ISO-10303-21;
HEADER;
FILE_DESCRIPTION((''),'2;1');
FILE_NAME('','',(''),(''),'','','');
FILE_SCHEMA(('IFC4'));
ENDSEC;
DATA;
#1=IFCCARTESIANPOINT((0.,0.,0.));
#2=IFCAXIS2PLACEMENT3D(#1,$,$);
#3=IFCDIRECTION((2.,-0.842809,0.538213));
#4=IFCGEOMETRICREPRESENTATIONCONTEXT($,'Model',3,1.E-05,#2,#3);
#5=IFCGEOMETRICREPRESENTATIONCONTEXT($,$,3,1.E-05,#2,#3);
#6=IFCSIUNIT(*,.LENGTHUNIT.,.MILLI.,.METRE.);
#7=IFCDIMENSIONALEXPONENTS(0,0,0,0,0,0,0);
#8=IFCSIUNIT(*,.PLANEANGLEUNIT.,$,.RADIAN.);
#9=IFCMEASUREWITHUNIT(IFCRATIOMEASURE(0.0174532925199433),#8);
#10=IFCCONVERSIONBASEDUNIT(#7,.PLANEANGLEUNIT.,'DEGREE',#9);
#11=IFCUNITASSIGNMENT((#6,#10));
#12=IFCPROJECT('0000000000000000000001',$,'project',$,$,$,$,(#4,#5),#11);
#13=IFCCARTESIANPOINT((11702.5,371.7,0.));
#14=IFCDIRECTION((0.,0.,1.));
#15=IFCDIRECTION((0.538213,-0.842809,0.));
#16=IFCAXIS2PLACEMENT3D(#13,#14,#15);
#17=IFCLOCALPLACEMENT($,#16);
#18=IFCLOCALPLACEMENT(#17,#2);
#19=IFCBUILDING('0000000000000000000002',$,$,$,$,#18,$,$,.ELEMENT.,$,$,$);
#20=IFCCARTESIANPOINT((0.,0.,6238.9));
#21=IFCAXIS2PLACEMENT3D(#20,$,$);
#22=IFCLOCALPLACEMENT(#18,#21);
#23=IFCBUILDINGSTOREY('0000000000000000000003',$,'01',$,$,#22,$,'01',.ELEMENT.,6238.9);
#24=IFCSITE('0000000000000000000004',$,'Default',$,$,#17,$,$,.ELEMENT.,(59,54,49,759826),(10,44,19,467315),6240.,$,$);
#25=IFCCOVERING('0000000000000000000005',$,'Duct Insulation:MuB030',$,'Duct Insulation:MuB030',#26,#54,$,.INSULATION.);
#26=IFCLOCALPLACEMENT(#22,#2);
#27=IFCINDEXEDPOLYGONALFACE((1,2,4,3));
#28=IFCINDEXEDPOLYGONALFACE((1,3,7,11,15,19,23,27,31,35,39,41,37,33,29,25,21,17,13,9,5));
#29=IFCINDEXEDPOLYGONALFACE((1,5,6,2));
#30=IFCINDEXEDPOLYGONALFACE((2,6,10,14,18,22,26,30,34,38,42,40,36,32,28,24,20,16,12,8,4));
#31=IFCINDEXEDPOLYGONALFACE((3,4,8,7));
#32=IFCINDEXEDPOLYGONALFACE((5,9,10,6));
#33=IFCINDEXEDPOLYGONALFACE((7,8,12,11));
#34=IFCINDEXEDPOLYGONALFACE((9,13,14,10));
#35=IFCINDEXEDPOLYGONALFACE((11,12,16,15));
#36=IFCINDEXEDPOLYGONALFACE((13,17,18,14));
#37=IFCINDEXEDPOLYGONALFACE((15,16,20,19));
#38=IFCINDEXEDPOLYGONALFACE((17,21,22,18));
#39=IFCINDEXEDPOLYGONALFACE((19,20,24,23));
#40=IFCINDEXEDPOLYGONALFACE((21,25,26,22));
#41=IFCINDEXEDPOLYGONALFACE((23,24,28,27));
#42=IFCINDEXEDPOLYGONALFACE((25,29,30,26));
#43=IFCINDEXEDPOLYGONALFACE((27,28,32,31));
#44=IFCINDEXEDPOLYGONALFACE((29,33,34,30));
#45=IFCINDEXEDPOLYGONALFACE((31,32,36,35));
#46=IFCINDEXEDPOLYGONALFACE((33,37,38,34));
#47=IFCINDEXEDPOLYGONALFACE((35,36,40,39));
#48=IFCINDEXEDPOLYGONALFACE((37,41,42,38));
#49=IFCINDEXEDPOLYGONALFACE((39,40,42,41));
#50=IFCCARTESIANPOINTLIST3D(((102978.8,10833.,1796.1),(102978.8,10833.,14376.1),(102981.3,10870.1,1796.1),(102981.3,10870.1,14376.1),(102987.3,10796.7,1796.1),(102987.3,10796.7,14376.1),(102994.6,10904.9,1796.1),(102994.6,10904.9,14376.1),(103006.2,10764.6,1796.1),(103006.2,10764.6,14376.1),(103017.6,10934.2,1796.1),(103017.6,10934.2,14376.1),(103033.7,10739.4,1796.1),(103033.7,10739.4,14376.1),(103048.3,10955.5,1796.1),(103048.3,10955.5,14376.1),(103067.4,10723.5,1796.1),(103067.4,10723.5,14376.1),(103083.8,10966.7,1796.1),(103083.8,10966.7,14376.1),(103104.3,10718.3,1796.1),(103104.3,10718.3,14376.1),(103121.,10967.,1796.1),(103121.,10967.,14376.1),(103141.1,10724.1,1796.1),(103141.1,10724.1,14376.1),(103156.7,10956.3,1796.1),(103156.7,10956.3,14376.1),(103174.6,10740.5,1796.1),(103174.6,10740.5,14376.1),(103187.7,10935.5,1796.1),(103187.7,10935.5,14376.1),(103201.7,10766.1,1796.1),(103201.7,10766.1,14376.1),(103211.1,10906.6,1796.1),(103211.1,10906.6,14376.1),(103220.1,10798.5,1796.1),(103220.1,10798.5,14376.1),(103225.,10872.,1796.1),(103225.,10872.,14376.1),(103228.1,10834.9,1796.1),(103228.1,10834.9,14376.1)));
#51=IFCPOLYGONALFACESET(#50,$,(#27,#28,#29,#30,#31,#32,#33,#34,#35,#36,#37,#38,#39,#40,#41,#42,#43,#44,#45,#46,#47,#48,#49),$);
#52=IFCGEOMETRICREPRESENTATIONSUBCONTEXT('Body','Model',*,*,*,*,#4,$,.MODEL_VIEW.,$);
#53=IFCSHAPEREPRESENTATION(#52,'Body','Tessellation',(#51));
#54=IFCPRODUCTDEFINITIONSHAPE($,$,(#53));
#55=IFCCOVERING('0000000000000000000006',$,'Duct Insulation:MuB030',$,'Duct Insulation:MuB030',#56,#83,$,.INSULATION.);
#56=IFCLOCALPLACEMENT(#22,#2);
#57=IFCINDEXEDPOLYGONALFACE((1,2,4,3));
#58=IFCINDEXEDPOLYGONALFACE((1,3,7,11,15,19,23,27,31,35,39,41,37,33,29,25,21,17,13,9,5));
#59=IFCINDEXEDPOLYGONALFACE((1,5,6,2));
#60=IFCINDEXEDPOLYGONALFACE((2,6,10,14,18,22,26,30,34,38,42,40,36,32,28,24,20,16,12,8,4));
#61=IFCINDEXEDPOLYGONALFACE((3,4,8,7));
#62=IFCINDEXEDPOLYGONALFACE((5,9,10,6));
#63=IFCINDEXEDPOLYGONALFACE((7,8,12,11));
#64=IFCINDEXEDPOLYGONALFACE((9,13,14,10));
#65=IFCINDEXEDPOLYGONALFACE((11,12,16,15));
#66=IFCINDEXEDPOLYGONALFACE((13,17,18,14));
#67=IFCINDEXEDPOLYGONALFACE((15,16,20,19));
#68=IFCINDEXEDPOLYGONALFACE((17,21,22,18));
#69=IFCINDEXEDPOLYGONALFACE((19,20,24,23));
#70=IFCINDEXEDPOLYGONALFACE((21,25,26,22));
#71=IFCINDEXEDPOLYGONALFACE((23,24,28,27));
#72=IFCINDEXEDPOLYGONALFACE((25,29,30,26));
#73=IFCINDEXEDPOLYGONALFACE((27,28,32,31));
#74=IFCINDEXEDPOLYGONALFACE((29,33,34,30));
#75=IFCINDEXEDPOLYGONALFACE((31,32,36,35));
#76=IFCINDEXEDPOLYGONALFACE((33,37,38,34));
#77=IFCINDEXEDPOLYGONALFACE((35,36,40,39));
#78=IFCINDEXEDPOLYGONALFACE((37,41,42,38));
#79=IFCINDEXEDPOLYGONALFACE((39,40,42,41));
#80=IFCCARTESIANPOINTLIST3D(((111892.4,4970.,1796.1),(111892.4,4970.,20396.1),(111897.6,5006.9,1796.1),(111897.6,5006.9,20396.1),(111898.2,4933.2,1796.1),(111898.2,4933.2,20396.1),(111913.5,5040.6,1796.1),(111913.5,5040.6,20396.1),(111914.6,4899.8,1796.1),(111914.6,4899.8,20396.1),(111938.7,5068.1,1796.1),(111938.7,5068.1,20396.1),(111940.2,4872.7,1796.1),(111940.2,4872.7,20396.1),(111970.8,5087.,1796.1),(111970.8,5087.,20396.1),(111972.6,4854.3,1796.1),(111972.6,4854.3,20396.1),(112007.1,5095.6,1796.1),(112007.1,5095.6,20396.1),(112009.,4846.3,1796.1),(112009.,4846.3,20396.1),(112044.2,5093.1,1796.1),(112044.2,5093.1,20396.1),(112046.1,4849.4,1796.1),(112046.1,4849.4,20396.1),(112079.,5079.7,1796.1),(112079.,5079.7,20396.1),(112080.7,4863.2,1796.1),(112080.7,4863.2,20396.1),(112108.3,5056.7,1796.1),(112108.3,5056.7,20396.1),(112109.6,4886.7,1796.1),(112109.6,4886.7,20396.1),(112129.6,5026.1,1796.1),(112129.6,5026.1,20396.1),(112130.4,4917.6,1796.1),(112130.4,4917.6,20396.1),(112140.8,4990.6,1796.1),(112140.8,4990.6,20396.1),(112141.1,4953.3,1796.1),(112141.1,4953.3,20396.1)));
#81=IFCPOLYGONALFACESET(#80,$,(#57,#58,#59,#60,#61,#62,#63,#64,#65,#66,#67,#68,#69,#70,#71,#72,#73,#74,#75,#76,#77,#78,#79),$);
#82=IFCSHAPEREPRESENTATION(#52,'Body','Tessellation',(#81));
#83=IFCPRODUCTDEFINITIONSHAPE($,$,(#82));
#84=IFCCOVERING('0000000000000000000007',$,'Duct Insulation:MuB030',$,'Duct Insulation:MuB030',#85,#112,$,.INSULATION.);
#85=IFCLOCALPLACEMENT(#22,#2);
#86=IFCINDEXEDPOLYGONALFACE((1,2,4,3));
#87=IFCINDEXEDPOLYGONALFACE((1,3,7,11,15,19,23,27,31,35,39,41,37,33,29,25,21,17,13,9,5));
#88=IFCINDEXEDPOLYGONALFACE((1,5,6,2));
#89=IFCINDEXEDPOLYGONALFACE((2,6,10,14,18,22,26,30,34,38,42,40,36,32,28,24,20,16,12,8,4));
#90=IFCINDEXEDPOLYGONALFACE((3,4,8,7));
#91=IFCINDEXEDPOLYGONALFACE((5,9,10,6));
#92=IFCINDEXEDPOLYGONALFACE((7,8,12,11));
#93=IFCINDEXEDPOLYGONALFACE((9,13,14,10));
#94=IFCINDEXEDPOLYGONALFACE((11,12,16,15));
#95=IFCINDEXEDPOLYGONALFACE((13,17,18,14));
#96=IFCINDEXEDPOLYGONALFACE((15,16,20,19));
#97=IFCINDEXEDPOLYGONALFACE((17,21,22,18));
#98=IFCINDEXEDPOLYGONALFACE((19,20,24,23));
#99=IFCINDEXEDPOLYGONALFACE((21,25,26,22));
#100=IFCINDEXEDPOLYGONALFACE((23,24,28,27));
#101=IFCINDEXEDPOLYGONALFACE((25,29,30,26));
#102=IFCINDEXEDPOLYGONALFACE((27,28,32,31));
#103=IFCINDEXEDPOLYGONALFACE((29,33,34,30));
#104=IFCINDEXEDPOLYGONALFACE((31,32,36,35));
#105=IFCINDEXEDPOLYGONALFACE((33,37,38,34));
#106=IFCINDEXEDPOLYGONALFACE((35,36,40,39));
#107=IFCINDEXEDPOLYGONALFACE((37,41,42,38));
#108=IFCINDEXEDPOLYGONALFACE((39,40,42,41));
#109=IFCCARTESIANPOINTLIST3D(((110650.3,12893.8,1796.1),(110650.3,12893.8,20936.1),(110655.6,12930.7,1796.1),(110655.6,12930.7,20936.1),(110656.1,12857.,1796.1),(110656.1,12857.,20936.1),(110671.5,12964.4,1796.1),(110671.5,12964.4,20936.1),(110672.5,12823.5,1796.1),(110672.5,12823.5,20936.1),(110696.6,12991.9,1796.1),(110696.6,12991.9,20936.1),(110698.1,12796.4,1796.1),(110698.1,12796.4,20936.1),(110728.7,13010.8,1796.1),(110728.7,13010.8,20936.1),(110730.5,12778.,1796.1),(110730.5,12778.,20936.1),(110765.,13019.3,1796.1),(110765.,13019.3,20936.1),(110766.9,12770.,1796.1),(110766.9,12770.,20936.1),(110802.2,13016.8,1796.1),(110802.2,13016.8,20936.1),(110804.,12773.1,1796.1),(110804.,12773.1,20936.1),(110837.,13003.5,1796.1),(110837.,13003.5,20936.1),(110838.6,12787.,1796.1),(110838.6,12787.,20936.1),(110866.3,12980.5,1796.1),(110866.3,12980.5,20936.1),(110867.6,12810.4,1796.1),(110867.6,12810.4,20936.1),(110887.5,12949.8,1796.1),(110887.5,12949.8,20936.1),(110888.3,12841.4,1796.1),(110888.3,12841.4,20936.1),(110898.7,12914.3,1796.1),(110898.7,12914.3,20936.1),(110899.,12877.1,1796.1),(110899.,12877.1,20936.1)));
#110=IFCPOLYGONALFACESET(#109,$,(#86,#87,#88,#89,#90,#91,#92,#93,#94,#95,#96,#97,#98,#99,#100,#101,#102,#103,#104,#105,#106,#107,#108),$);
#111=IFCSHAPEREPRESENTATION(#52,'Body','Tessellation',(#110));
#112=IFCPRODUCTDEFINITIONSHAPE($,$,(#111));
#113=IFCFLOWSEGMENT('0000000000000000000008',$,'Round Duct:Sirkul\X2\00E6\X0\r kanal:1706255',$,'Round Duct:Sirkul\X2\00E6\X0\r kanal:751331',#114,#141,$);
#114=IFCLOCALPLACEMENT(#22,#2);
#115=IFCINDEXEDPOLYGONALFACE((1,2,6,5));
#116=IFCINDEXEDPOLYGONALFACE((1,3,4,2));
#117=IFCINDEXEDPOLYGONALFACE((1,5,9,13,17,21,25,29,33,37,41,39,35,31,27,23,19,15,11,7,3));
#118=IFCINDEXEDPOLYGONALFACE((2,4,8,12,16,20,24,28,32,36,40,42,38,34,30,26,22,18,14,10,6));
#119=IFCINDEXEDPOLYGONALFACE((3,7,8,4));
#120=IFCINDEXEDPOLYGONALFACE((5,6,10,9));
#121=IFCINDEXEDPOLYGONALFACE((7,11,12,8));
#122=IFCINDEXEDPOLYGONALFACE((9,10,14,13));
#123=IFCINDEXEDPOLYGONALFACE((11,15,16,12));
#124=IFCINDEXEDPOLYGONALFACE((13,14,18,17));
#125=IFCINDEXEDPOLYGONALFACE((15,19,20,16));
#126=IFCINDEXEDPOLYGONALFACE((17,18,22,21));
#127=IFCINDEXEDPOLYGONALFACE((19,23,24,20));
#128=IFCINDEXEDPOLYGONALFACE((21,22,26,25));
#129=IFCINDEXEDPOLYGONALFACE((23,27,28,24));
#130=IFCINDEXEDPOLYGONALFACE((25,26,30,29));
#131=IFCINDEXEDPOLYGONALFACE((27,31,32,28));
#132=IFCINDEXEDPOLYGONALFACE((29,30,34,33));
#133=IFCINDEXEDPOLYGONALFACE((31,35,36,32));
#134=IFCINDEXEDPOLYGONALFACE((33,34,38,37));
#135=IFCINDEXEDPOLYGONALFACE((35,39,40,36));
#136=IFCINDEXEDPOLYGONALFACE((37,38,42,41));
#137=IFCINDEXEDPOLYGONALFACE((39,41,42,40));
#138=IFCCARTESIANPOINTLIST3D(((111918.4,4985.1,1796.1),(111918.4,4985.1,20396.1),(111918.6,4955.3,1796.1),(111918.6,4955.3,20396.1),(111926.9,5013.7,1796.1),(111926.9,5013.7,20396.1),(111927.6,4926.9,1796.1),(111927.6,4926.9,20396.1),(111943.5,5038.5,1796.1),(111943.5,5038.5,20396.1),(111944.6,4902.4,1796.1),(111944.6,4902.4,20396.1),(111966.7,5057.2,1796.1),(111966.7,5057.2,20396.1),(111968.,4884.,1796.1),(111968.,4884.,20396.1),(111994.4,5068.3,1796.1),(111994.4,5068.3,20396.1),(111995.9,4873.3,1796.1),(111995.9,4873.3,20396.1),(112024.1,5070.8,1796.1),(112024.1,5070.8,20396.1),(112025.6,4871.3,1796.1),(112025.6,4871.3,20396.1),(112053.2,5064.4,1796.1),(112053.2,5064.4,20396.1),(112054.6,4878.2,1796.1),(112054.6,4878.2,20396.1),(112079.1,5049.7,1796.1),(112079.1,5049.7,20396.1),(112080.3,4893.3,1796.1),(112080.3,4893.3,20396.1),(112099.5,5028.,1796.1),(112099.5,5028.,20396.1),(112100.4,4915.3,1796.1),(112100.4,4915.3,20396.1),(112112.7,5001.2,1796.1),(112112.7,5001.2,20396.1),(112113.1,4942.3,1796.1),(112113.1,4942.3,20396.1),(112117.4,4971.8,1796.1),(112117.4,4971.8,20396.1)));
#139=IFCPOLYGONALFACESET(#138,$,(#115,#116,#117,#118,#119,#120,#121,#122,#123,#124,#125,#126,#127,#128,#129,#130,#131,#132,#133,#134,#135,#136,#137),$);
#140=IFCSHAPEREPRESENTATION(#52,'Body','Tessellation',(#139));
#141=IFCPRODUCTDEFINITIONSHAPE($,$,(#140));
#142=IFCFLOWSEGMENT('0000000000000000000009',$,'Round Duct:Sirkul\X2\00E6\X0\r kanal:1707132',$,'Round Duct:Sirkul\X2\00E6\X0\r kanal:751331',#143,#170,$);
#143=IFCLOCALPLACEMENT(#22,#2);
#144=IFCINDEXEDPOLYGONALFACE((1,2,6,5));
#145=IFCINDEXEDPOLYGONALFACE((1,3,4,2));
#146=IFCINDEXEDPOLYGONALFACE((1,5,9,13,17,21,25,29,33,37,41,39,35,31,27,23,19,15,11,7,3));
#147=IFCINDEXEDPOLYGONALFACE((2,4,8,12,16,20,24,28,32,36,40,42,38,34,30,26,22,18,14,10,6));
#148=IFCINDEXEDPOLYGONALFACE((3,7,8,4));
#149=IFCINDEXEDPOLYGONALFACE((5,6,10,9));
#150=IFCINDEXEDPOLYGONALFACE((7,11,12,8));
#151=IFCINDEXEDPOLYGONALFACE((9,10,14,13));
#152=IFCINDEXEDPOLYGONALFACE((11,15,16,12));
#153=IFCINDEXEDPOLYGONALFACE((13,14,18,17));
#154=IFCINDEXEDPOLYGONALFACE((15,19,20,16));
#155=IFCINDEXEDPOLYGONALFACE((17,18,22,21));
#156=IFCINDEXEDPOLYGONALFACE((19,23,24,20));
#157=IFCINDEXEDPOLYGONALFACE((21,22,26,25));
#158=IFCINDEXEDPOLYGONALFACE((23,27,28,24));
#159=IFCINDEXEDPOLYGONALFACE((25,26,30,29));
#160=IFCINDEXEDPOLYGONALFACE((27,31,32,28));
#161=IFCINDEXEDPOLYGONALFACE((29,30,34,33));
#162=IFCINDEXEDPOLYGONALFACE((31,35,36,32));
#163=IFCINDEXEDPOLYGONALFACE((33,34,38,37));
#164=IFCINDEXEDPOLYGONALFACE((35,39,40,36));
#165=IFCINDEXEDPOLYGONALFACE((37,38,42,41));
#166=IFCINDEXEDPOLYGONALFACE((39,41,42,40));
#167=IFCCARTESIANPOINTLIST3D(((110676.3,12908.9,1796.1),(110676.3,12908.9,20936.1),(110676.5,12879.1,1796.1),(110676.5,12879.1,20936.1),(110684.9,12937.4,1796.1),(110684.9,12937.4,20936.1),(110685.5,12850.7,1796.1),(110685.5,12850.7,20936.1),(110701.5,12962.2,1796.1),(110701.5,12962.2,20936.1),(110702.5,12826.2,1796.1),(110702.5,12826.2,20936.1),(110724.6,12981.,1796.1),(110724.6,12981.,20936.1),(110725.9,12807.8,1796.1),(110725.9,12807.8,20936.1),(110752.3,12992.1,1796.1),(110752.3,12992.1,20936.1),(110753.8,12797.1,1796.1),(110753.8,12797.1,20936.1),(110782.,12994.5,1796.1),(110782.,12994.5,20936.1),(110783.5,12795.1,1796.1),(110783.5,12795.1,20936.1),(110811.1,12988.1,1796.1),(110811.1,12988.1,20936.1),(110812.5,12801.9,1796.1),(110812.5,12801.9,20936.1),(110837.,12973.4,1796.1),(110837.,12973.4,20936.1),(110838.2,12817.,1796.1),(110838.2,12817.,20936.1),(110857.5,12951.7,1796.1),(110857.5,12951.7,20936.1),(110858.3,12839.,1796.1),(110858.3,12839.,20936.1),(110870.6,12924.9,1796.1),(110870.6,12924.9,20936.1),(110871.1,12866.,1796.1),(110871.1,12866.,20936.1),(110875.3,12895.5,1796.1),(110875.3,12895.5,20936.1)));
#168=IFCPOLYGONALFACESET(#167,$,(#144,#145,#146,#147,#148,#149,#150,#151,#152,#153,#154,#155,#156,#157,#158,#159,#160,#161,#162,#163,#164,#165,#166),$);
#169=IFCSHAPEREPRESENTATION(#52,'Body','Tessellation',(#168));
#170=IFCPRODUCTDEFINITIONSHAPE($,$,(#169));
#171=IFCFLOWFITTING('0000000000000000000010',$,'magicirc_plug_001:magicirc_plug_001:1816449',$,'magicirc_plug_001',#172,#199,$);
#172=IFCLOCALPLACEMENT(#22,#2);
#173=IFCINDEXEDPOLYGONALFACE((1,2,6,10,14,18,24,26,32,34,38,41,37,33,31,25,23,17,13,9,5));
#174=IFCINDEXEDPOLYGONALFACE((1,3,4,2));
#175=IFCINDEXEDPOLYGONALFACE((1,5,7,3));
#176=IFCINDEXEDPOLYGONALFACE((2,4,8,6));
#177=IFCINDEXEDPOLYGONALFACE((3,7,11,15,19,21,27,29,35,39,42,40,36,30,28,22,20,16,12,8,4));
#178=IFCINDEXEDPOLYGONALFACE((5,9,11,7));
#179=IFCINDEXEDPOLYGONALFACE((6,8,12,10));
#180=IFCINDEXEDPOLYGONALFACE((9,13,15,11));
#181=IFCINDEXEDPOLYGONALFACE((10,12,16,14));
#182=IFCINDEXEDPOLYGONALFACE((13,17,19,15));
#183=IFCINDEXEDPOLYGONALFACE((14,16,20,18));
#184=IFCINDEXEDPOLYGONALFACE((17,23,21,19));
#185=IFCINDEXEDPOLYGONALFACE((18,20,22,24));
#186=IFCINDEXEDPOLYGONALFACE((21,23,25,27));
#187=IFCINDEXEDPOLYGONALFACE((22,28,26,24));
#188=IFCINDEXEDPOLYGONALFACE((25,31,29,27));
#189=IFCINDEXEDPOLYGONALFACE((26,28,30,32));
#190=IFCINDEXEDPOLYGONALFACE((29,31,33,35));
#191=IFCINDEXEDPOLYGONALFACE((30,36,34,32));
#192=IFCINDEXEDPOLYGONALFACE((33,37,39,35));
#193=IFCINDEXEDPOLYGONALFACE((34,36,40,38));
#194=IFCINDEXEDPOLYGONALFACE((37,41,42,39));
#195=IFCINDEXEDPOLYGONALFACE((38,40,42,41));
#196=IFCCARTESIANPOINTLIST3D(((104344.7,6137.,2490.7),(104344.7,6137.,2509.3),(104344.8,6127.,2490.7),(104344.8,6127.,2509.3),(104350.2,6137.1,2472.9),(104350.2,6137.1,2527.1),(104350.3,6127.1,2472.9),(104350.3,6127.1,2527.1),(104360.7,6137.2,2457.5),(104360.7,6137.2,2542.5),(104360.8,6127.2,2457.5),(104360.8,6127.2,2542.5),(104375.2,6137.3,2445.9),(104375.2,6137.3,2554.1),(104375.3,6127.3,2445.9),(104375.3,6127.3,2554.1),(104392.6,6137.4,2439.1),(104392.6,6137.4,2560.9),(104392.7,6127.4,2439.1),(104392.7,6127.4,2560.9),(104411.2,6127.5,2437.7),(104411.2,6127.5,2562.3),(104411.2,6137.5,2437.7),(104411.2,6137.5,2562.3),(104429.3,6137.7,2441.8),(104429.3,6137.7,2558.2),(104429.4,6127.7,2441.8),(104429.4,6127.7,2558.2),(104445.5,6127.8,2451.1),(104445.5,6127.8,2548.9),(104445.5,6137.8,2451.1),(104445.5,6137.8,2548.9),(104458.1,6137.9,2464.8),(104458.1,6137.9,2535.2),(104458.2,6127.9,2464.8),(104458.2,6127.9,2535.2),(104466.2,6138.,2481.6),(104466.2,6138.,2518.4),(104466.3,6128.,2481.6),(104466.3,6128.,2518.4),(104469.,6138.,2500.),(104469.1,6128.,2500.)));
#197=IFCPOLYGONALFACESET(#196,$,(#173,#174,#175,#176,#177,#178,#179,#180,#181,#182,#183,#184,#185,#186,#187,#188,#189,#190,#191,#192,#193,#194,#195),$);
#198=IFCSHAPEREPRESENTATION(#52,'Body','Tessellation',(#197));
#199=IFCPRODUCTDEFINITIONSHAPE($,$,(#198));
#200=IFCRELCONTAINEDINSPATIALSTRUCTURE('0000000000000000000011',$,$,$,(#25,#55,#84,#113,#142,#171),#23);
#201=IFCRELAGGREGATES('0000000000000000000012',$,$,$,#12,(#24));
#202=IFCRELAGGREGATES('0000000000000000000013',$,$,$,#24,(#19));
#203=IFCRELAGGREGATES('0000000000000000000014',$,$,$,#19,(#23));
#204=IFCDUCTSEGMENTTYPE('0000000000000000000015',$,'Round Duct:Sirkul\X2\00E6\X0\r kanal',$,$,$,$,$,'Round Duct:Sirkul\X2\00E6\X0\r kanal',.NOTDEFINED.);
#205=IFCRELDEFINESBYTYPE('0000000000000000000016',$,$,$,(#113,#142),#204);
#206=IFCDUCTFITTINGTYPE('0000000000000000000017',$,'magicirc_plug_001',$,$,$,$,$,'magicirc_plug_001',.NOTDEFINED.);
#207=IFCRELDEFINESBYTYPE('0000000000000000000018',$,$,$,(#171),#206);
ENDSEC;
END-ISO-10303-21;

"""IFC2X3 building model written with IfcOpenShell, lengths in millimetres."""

from ifc_helpers import new_model, entity, si_unit, converted_unit, direction, frame, frame_2d, origin, origin_2d_with_axis, place, context, subcontext, project, spatial, circle, extrude, source, transform, mapped, type_object, type_shapes, element, save


model = new_model("IFC2X3")

# Units and contexts
model_context = context("Model", 3, precision=1e-05, world=origin(), true_north=direction((2.0, -0.842809, 0.538213)))
context_of_model = context(None, 3, precision=1e-05, world=origin(), true_north=direction((2.0, -0.842809, 0.538213)))
body_context = subcontext(model_context, "Body", "Model", "MODEL_VIEW")
ifc_project = project(units=[si_unit("LENGTHUNIT", "METRE", prefix="MILLI"), converted_unit("PLANEANGLEUNIT", "DEGREE", entity("IfcRatioMeasure", 0.0174532925199433), si_unit("PLANEANGLEUNIT", "RADIAN"), dimensions=[0, 0, 0, 0, 0, 0, 0])], contexts=[model_context, context_of_model])

# Site, building, storey
site_placement = place(None, frame((11702.5, 371.7, 0.0), z_axis=(0.0, 0.0, 1.0), x_axis=(0.538213, -0.842809, 0.0)))
site = spatial("IfcSite", under=ifc_project, at=site_placement, Name="Default", CompositionType="ELEMENT", RefLatitude=(59, 54, 49, 759826), RefLongitude=(10, 44, 19, 467315), RefElevation=6240.0)
building_placement = place(site_placement, origin())
building = spatial("IfcBuilding", under=site, at=building_placement, CompositionType="ELEMENT")
storey_placement = place(building_placement, frame((0.0, 0.0, 6238.9)))
storey = spatial("IfcBuildingStorey", under=building, at=storey_placement, Name="01", LongName="01", CompositionType="ELEMENT", Elevation=6238.9)

# Coverings
covering_1_placement = place(storey_placement, origin())
element("IfcCovering", 1, at=covering_1_placement, inside=storey, Name="Duct Insulation:MuB030", ObjectType="Duct Insulation:MuB030", PredefinedType="INSULATION", context=body_context, shape_type="SweptSolid", body=[
    extrude(circle(Radius=125.0, at=frame_2d((0.0, 0.0), x_axis=(1.0, 0.0))), frame((103103.4, 10843.3, 1796.1), z_axis=(0.0, 0.0, 1.0), x_axis=(0.007643, -0.999971, 0.0)), (0.0, 0.0, 1.0), 12580.0),
])
covering_2_placement = place(storey_placement, origin())
element("IfcCovering", 2, at=covering_2_placement, inside=storey, Name="Duct Insulation:MuB030", ObjectType="Duct Insulation:MuB030", PredefinedType="INSULATION", context=body_context, shape_type="SweptSolid", body=[
    extrude(circle(Radius=125.0, at=origin_2d_with_axis()), frame((112017.4, 4971.0, 1796.1), z_axis=(0.0, 0.0, 1.0), x_axis=(-0.999971, -0.007643, 0.0)), (0.0, 0.0, 1.0), 18600.0),
])
covering_3_placement = place(storey_placement, origin())
element("IfcCovering", 3, at=covering_3_placement, inside=storey, Name="Duct Insulation:MuB030", ObjectType="Duct Insulation:MuB030", PredefinedType="INSULATION", context=body_context, shape_type="SweptSolid", body=[
    extrude(circle(Radius=125.0, at=origin_2d_with_axis()), frame((110775.3, 12894.7, 1796.1), z_axis=(0.0, 0.0, 1.0), x_axis=(-0.999971, -0.007643, 0.0)), (0.0, 0.0, 1.0), 19140.0),
])

# Flow segments
duct_segment_type = type_object("IfcDuctSegmentType", Name="Round Duct:Sirkulær kanal", ElementType="Round Duct:Sirkulær kanal", PredefinedType="NOTDEFINED")
flow_segment_1_placement = place(storey_placement, origin())
element("IfcFlowSegment", 4, at=flow_segment_1_placement, inside=storey, type_object=duct_segment_type, Name="Round Duct:Sirkulær kanal:1706255", ObjectType="Round Duct:Sirkulær kanal:751331", context=body_context, shape_type="SweptSolid", body=[
    extrude(circle(Radius=100.0, at=origin_2d_with_axis()), frame((112017.4, 4971.0, 1796.1), z_axis=(0.0, 0.0, 1.0), x_axis=(0.999971, 0.007643, 0.0)), (0.0, 0.0, 1.0), 18600.0),
])
flow_segment_2_placement = place(storey_placement, origin())
element("IfcFlowSegment", 5, at=flow_segment_2_placement, inside=storey, type_object=duct_segment_type, Name="Round Duct:Sirkulær kanal:1707132", ObjectType="Round Duct:Sirkulær kanal:751331", context=body_context, shape_type="SweptSolid", body=[
    extrude(circle(Radius=100.0, at=frame_2d((0.0, 0.0), x_axis=(1.0, 0.0))), frame((110775.3, 12894.7, 1796.1), z_axis=(0.0, 0.0, 1.0), x_axis=(0.999971, 0.007643, 0.0)), (0.0, 0.0, 1.0), 19140.0),
])

# Flow fitting
duct_fitting_type_1 = type_object("IfcDuctFittingType", Name="magicirc_plug_001", ElementType="magicirc_plug_001", PredefinedType="NOTDEFINED")
shared_shape_1 = source(origin(), body_context, "Body", "SweptSolid", [
    extrude(circle(Radius=62.5, at=frame_2d((0.0, 0.0), x_axis=(1.0, 0.0))), frame((0.0, 0.0, 0.0), z_axis=(1.0, 0.0, 0.0), x_axis=(0.0, 1.0, 0.0)), (0.0, 0.0, 1.0), 10.0),
])
type_shapes(duct_fitting_type_1, [shared_shape_1])
for number, where, z_axis, x_axis, name in (
    (6, (104406.5, 6137.5, 2500.0), (0.0, 0.0, 1.0), (0.007643, -0.999971, 0.0), "magicirc_plug_001:magicirc_plug_001:1816449"),
):
    element("IfcFlowFitting", number, at=place(storey_placement, frame(where, z_axis=z_axis, x_axis=x_axis)), inside=storey, type_object=duct_fitting_type_1, Name=name, ObjectType="magicirc_plug_001", context=body_context, shape_type="MappedRepresentation", body=[
        mapped(shared_shape_1, transform((0.0, 0.0, 0.0), scale=1.0)),
    ])

save(model, "model.ifc")
